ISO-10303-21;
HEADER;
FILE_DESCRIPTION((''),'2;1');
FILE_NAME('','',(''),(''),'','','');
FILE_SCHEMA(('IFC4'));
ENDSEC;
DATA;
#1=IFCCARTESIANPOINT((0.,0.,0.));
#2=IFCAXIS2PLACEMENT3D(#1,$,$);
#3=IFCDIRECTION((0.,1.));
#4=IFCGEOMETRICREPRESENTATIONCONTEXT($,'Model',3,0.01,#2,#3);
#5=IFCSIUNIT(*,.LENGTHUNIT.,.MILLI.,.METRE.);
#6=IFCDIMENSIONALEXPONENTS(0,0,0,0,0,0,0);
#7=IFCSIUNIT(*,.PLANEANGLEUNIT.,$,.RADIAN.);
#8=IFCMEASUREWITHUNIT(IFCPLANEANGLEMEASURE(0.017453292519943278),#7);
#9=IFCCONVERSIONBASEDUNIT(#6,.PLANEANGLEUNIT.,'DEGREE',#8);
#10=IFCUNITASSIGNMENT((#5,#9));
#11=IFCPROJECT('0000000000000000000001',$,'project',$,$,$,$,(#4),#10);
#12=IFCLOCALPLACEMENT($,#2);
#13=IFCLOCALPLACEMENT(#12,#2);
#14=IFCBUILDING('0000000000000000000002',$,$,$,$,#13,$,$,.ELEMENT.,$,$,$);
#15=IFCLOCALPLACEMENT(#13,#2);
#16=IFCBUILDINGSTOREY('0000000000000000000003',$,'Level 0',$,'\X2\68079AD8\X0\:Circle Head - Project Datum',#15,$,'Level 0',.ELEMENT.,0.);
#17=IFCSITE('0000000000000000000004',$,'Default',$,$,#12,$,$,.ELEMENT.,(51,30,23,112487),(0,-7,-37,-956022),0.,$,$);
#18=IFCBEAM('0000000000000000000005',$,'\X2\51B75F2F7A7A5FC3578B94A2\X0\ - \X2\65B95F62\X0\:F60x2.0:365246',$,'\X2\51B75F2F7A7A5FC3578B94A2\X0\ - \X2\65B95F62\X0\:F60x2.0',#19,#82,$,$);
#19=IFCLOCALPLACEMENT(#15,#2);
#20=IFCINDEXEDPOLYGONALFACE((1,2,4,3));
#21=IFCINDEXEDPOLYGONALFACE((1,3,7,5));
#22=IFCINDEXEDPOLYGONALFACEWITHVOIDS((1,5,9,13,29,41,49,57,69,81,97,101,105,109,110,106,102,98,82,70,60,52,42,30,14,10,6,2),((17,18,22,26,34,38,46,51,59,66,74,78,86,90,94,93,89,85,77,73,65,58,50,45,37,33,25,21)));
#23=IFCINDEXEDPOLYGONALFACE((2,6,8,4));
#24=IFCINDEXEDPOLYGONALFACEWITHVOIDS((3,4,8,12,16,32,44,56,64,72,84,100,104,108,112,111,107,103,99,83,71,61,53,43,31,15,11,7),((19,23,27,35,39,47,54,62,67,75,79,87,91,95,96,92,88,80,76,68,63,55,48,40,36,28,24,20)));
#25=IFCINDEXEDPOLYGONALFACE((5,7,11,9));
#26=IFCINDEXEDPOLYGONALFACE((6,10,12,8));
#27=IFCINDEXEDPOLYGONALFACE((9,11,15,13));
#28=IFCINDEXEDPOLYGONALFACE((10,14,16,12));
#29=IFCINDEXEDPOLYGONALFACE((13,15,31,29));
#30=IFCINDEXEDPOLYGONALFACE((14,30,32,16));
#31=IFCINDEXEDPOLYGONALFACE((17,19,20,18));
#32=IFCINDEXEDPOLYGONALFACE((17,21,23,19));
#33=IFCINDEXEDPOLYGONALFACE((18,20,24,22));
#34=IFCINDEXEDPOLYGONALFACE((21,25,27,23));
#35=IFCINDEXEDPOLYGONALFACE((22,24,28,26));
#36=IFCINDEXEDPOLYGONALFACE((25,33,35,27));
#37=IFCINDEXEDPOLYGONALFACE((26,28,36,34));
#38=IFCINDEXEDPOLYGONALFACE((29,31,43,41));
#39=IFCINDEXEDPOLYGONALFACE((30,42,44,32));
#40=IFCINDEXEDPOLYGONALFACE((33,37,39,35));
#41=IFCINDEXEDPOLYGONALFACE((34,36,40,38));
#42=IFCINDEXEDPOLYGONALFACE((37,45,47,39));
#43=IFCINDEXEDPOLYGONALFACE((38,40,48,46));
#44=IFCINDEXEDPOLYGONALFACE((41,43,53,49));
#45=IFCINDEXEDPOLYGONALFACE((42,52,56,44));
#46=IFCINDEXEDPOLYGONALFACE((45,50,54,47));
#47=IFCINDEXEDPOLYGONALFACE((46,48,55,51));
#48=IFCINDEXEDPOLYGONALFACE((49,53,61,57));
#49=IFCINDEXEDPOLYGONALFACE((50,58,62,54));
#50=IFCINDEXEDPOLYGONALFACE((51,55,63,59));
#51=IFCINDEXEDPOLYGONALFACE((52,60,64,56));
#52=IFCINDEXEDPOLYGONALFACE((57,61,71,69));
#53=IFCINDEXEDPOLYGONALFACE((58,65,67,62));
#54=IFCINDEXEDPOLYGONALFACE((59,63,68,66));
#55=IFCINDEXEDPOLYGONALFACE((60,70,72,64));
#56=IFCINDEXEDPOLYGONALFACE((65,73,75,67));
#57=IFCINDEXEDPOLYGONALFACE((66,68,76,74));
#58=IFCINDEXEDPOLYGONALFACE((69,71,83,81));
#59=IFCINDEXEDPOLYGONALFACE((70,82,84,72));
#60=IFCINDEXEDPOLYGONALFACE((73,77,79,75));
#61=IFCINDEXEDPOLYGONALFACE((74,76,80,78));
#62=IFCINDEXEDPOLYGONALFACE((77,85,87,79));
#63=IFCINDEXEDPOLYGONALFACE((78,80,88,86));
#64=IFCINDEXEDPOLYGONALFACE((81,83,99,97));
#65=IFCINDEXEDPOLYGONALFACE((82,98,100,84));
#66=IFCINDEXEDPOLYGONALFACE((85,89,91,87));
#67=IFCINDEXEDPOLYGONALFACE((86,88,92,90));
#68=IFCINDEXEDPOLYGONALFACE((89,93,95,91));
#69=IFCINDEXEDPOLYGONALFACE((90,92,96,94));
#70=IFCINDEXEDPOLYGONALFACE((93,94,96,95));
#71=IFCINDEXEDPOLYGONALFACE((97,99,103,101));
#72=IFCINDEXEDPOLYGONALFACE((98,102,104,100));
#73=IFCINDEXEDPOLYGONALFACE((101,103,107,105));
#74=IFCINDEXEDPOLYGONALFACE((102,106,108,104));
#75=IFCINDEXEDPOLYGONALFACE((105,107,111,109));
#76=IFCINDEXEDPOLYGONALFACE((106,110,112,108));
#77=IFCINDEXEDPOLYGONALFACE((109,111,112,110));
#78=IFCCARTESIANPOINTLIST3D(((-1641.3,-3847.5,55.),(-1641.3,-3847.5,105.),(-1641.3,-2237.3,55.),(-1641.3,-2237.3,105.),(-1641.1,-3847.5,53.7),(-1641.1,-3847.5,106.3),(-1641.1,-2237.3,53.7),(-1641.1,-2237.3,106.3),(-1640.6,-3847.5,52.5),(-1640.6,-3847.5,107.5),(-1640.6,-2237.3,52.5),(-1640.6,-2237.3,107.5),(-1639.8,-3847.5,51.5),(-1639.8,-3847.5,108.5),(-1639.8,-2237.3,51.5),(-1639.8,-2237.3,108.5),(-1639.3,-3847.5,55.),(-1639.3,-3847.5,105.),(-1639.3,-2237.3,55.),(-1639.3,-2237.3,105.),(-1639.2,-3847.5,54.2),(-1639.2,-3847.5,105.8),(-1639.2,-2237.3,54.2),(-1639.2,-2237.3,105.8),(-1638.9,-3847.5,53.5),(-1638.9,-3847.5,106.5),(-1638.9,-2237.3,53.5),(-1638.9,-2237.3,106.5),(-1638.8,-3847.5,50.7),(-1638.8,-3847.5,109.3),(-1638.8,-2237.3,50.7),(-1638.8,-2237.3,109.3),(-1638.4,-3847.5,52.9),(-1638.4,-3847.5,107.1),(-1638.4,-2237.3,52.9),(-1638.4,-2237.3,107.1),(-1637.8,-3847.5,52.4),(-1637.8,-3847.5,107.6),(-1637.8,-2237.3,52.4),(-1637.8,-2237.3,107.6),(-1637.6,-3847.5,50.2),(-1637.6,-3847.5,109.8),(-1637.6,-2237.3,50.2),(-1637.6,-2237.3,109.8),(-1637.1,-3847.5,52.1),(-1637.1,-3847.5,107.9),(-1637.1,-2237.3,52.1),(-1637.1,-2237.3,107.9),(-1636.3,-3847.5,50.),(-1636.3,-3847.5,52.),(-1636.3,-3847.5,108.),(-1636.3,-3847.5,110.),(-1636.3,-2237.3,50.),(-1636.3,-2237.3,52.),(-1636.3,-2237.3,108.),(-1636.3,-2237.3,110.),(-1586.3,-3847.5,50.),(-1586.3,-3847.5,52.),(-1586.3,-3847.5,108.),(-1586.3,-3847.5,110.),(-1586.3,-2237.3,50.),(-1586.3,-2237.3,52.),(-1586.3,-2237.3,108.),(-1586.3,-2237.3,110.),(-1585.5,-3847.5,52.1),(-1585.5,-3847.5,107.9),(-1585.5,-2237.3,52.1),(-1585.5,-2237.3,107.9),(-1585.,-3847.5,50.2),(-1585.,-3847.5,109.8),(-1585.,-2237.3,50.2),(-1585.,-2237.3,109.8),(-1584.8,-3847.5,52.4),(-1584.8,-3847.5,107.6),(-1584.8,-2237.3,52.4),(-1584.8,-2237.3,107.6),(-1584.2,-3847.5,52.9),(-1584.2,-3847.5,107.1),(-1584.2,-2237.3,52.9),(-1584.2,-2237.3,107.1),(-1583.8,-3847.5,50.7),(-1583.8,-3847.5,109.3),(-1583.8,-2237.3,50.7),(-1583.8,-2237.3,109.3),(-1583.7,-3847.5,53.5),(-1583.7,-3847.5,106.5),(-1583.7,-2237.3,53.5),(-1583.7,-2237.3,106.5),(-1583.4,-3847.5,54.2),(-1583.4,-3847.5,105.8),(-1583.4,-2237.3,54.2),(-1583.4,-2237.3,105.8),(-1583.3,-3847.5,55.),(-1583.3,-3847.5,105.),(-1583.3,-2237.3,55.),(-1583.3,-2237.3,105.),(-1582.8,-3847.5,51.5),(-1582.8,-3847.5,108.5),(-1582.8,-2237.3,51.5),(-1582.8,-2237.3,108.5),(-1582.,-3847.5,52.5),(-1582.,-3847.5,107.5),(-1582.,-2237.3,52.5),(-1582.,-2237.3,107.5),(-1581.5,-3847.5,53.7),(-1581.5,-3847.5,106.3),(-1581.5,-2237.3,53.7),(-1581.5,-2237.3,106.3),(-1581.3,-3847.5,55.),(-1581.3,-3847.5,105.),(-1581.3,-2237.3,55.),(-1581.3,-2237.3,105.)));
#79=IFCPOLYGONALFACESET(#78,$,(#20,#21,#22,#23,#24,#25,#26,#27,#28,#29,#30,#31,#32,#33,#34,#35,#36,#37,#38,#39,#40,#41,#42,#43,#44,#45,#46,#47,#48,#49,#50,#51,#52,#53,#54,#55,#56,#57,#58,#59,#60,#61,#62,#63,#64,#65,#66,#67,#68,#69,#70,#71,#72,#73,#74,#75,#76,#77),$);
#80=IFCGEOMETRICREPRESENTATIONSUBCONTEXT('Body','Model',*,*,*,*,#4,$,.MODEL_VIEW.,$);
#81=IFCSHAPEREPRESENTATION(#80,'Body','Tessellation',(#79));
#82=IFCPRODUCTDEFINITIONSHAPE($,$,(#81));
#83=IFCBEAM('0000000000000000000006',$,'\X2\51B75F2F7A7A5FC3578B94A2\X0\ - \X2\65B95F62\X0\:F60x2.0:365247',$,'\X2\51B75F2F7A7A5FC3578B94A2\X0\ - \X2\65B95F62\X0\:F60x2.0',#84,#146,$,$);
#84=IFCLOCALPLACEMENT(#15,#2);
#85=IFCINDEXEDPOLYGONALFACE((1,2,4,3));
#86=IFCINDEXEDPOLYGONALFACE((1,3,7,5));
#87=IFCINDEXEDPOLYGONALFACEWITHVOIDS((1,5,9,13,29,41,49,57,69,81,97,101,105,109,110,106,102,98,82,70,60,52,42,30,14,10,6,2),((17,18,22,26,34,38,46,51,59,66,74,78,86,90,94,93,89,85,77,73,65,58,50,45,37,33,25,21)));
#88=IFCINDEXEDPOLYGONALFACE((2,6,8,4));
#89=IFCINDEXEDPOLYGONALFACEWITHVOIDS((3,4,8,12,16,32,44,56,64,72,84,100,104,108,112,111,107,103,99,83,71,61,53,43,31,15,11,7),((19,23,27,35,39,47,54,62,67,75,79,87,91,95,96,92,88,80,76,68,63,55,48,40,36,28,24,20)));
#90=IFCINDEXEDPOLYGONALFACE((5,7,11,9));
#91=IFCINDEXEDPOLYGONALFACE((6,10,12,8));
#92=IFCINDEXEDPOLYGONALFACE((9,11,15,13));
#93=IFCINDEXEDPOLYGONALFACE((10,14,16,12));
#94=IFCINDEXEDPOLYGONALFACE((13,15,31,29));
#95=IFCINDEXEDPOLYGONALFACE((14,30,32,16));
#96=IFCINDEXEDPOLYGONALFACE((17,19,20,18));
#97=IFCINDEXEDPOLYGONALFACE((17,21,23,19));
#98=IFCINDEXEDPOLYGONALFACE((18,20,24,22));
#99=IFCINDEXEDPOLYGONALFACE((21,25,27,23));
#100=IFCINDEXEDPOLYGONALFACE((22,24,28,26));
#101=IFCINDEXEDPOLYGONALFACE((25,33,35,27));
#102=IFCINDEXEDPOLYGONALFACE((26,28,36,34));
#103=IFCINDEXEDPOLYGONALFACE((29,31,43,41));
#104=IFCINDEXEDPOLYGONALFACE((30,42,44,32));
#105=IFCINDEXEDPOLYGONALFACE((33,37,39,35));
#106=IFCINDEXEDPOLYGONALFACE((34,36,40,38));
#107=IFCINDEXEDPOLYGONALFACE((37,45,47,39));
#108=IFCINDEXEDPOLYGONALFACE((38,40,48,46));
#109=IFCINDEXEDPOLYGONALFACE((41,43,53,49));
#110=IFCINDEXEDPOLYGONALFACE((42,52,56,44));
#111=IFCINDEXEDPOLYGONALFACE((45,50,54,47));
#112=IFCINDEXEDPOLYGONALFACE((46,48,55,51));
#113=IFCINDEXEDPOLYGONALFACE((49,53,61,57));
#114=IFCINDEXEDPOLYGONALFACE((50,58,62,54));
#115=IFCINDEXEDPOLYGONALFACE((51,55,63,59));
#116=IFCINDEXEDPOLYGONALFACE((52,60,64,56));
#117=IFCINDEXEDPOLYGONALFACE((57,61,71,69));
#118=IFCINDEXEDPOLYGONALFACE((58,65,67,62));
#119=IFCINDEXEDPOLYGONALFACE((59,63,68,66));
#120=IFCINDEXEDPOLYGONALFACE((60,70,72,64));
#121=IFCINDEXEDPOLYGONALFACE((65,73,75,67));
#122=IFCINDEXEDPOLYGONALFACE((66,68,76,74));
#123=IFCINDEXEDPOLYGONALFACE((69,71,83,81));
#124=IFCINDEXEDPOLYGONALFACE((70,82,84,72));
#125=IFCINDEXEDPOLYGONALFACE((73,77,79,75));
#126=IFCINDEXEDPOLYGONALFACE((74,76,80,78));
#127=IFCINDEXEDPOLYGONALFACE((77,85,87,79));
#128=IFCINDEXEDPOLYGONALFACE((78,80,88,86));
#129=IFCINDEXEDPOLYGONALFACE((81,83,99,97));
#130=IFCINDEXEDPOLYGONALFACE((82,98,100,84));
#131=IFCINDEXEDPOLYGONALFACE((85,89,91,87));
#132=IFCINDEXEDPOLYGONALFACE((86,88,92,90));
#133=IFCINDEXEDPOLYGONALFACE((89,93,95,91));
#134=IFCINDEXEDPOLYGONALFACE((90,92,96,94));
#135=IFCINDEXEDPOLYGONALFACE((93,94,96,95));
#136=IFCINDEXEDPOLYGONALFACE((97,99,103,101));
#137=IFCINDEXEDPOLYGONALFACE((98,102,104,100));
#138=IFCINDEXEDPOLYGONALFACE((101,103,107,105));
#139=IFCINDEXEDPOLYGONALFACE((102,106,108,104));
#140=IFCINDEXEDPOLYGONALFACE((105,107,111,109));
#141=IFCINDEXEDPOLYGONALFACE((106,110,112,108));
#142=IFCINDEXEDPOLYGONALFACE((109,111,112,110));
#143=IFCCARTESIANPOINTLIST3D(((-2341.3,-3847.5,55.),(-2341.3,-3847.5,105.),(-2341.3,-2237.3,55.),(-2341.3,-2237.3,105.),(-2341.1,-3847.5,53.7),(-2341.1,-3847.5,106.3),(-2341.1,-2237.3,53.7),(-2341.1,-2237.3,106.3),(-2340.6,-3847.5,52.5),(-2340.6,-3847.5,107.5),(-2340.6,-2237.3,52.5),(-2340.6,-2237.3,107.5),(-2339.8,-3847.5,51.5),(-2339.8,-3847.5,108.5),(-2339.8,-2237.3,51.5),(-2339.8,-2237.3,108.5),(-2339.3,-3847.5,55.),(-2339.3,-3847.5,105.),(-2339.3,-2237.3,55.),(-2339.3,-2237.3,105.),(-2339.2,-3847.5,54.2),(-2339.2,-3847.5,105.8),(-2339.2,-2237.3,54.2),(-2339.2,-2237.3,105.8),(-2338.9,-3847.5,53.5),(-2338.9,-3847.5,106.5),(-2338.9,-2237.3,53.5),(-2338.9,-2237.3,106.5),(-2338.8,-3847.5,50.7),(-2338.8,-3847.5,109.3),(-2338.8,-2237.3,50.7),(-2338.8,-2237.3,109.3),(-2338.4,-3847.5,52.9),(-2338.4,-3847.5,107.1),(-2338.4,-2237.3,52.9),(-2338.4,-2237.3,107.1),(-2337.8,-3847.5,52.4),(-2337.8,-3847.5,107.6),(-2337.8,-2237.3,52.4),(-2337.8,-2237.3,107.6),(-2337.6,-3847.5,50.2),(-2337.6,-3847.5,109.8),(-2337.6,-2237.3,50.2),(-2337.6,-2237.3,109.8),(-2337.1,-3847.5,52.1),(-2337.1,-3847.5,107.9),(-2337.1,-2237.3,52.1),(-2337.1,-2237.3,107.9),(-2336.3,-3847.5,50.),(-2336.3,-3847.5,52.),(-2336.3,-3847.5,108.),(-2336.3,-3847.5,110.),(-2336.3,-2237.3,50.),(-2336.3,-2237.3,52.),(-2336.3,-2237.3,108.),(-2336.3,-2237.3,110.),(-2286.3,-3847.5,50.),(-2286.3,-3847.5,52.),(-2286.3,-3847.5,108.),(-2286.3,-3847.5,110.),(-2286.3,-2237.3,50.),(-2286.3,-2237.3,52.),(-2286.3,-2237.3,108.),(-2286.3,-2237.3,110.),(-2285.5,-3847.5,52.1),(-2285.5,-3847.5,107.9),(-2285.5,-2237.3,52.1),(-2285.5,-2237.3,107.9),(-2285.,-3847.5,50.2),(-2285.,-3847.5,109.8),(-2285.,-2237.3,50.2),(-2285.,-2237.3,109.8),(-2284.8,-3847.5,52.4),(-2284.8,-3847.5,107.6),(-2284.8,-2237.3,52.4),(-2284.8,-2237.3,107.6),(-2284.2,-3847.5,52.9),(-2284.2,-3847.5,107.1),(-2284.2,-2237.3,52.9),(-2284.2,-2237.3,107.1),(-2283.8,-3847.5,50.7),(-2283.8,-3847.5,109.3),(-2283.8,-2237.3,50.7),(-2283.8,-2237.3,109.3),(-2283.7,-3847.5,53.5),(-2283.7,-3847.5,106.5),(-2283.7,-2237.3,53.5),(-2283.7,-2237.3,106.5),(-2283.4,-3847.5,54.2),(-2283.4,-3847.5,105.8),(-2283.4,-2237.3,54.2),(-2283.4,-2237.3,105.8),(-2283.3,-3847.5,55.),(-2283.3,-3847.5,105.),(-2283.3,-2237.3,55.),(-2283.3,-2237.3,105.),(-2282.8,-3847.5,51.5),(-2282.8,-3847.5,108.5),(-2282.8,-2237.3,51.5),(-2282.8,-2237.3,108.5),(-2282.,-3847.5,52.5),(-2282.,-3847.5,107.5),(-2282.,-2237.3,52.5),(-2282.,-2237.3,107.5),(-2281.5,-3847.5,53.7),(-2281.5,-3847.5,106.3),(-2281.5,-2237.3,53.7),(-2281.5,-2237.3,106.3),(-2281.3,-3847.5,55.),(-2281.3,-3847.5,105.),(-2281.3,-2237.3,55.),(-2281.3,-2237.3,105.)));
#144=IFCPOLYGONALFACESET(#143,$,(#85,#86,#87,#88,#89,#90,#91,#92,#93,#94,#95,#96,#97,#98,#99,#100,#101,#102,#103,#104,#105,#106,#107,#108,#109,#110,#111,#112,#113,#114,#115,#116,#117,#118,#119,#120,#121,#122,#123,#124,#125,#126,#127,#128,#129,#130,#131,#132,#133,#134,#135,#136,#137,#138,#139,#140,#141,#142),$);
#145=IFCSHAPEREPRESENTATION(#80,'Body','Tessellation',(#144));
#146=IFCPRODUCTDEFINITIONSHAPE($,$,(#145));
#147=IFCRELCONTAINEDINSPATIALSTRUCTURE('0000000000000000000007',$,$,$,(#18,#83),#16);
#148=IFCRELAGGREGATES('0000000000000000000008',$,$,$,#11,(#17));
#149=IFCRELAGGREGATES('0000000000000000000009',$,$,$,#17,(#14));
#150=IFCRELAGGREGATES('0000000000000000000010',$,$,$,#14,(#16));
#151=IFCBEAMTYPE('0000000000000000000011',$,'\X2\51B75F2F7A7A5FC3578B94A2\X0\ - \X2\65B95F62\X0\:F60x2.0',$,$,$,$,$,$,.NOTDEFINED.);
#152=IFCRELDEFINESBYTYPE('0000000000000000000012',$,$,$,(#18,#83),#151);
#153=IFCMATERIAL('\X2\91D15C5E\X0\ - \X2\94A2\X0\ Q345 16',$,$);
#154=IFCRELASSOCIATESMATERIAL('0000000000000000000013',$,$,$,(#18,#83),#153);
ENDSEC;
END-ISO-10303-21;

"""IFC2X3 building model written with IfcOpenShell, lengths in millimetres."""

from ifc_helpers import new_model, entity, si_unit, converted_unit, direction, frame, frame_2d, origin, place, context, subcontext, project, spatial, polyline, circle_curve, parameter, trimmed, segment, composite_curve, outline, extrude, material, type_object, element, save


model = new_model("IFC2X3")

# Units and contexts
model_context = context("Model", 3, precision=0.01, world=origin(), true_north=direction((0.0, 1.0)))
body_context = subcontext(model_context, "Body", "Model", "MODEL_VIEW")
ifc_project = project(units=[si_unit("LENGTHUNIT", "METRE", prefix="MILLI"), converted_unit("PLANEANGLEUNIT", "DEGREE", entity("IfcPlaneAngleMeasure", 0.017453292519943278), si_unit("PLANEANGLEUNIT", "RADIAN"), dimensions=[0, 0, 0, 0, 0, 0, 0])], contexts=[model_context])

# Site, building, storey
site_placement = place(None, origin())
site = spatial("IfcSite", under=ifc_project, at=site_placement, Name="Default", CompositionType="ELEMENT", RefLatitude=(51, 30, 23, 112487), RefLongitude=(0, -7, -37, -956022), RefElevation=0.0)
building_placement = place(site_placement, origin())
building = spatial("IfcBuilding", under=site, at=building_placement, CompositionType="ELEMENT")
storey_placement = place(building_placement, origin())
storey = spatial("IfcBuildingStorey", under=building, at=storey_placement, Name="Level 0", ObjectType="标高:Circle Head - Project Datum", LongName="Level 0", CompositionType="ELEMENT", Elevation=0.0)

# Beams
ifc_material_1 = material(Name="金属 - 钢 Q345 16")
beam_type_1 = type_object("IfcBeamType", Name="冷弯空心型钢 - 方形:F60x2.0", PredefinedType="NOTDEFINED")
beam_1_placement = place(storey_placement, frame((-1611.3, -3815.6, 110.0), z_axis=(0.0, 0.0, 1.0), x_axis=(0.0, 1.0, 0.0)))
element("IfcBeam", 1, at=beam_1_placement, inside=storey, type_object=beam_type_1, material=ifc_material_1, Name="冷弯空心型钢 - 方形:F60x2.0:365246", ObjectType="冷弯空心型钢 - 方形:F60x2.0", context=body_context, shape_type="SweptSolid", body=[
    extrude(outline(composite_curve([segment(polyline([(-25.0, -30.0), (25.0, -30.0)]), True, "CONTINUOUS"), segment(trimmed(circle_curve(frame_2d((25.0, -25.0), x_axis=(1.0, 0.0)), 5.0), [parameter(270.0)], [parameter(360.0)], True, "PARAMETER"), True, "CONTINUOUS"), segment(polyline([(30.0, -25.0), (30.0, 25.0)]), True, "CONTINUOUS"), segment(trimmed(circle_curve(frame_2d((25.0, 25.0), x_axis=(1.0, 0.0)), 5.0), [parameter(360.0)], [parameter(90.0)], True, "PARAMETER"), True, "CONTINUOUS"), segment(polyline([(25.0, 30.0), (-25.0, 30.0)]), True, "CONTINUOUS"), segment(trimmed(circle_curve(frame_2d((-25.0, 25.0), x_axis=(1.0, 0.0)), 5.0), [parameter(90.0)], [parameter(180.0)], True, "PARAMETER"), True, "CONTINUOUS"), segment(polyline([(-30.0, 25.0), (-30.0, -25.0)]), True, "CONTINUOUS"), segment(trimmed(circle_curve(frame_2d((-25.0, -25.0), x_axis=(1.0, 0.0)), 5.0), [parameter(180.0)], [parameter(270.0)], True, "PARAMETER"), True, "CONTINUOUS")], self_intersect=False), holes=[composite_curve([segment(trimmed(circle_curve(frame_2d((-25.0, -25.0), x_axis=(1.0, 0.0)), 3.0), [parameter(180.0)], [parameter(270.0)], True, "PARAMETER"), False, "CONTINUOUS"), segment(polyline([(-28.0, -25.0), (-28.0, 25.0)]), True, "CONTINUOUS"), segment(trimmed(circle_curve(frame_2d((-25.0, 25.0), x_axis=(1.0, 0.0)), 3.0), [parameter(90.0)], [parameter(180.0)], True, "PARAMETER"), False, "CONTINUOUS"), segment(polyline([(-25.0, 28.0), (25.0, 28.0)]), True, "CONTINUOUS"), segment(trimmed(circle_curve(frame_2d((25.0, 25.0), x_axis=(1.0, 0.0)), 3.0), [parameter(0.0)], [parameter(90.0)], True, "PARAMETER"), False, "CONTINUOUS"), segment(polyline([(28.0, 25.0), (28.0, -25.0)]), True, "CONTINUOUS"), segment(trimmed(circle_curve(frame_2d((25.0, -25.0), x_axis=(1.0, 0.0)), 3.0), [parameter(270.0)], [parameter(360.0)], True, "PARAMETER"), False, "CONTINUOUS"), segment(polyline([(25.0, -28.0), (-25.0, -28.0)]), True, "CONTINUOUS")], self_intersect=False)]), frame((-31.9, 0.0, -30.0), z_axis=(1.0, 0.0, 0.0), x_axis=(0.0, -1.0, 0.0)), (0.0, 0.0, 1.0), 1610.2),
])
beam_2_placement = place(storey_placement, frame((-2311.3, -3815.6, 110.0), z_axis=(0.0, 0.0, 1.0), x_axis=(0.0, 1.0, 0.0)))
element("IfcBeam", 2, at=beam_2_placement, inside=storey, type_object=beam_type_1, material=ifc_material_1, Name="冷弯空心型钢 - 方形:F60x2.0:365247", ObjectType="冷弯空心型钢 - 方形:F60x2.0", context=body_context, shape_type="SweptSolid", body=[
    extrude(outline(composite_curve([segment(polyline([(-25.0, -30.0), (25.0, -30.0)]), True, "CONTINUOUS"), segment(trimmed(circle_curve(frame_2d((25.0, -25.0), x_axis=(1.0, 0.0)), 5.0), [parameter(270.0)], [parameter(360.0)], True, "PARAMETER"), True, "CONTINUOUS"), segment(polyline([(30.0, -25.0), (30.0, 25.0)]), True, "CONTINUOUS"), segment(trimmed(circle_curve(frame_2d((25.0, 25.0), x_axis=(1.0, 0.0)), 5.0), [parameter(360.0)], [parameter(90.0)], True, "PARAMETER"), True, "CONTINUOUS"), segment(polyline([(25.0, 30.0), (-25.0, 30.0)]), True, "CONTINUOUS"), segment(trimmed(circle_curve(frame_2d((-25.0, 25.0), x_axis=(1.0, 0.0)), 5.0), [parameter(90.0)], [parameter(180.0)], True, "PARAMETER"), True, "CONTINUOUS"), segment(polyline([(-30.0, 25.0), (-30.0, -25.0)]), True, "CONTINUOUS"), segment(trimmed(circle_curve(frame_2d((-25.0, -25.0), x_axis=(1.0, 0.0)), 5.0), [parameter(180.0)], [parameter(270.0)], True, "PARAMETER"), True, "CONTINUOUS")], self_intersect=False), holes=[composite_curve([segment(trimmed(circle_curve(frame_2d((-25.0, -25.0), x_axis=(1.0, 0.0)), 3.0), [parameter(180.0)], [parameter(270.0)], True, "PARAMETER"), False, "CONTINUOUS"), segment(polyline([(-28.0, -25.0), (-28.0, 25.0)]), True, "CONTINUOUS"), segment(trimmed(circle_curve(frame_2d((-25.0, 25.0), x_axis=(1.0, 0.0)), 3.0), [parameter(90.0)], [parameter(180.0)], True, "PARAMETER"), False, "CONTINUOUS"), segment(polyline([(-25.0, 28.0), (25.0, 28.0)]), True, "CONTINUOUS"), segment(trimmed(circle_curve(frame_2d((25.0, 25.0), x_axis=(1.0, 0.0)), 3.0), [parameter(0.0)], [parameter(90.0)], True, "PARAMETER"), False, "CONTINUOUS"), segment(polyline([(28.0, 25.0), (28.0, -25.0)]), True, "CONTINUOUS"), segment(trimmed(circle_curve(frame_2d((25.0, -25.0), x_axis=(1.0, 0.0)), 3.0), [parameter(270.0)], [parameter(360.0)], True, "PARAMETER"), False, "CONTINUOUS"), segment(polyline([(25.0, -28.0), (-25.0, -28.0)]), True, "CONTINUOUS")], self_intersect=False)]), frame((-31.9, 0.0, -30.0), z_axis=(1.0, 0.0, 0.0), x_axis=(0.0, -1.0, 0.0)), (0.0, 0.0, 1.0), 1610.2),
])

save(model, "model.ifc")
